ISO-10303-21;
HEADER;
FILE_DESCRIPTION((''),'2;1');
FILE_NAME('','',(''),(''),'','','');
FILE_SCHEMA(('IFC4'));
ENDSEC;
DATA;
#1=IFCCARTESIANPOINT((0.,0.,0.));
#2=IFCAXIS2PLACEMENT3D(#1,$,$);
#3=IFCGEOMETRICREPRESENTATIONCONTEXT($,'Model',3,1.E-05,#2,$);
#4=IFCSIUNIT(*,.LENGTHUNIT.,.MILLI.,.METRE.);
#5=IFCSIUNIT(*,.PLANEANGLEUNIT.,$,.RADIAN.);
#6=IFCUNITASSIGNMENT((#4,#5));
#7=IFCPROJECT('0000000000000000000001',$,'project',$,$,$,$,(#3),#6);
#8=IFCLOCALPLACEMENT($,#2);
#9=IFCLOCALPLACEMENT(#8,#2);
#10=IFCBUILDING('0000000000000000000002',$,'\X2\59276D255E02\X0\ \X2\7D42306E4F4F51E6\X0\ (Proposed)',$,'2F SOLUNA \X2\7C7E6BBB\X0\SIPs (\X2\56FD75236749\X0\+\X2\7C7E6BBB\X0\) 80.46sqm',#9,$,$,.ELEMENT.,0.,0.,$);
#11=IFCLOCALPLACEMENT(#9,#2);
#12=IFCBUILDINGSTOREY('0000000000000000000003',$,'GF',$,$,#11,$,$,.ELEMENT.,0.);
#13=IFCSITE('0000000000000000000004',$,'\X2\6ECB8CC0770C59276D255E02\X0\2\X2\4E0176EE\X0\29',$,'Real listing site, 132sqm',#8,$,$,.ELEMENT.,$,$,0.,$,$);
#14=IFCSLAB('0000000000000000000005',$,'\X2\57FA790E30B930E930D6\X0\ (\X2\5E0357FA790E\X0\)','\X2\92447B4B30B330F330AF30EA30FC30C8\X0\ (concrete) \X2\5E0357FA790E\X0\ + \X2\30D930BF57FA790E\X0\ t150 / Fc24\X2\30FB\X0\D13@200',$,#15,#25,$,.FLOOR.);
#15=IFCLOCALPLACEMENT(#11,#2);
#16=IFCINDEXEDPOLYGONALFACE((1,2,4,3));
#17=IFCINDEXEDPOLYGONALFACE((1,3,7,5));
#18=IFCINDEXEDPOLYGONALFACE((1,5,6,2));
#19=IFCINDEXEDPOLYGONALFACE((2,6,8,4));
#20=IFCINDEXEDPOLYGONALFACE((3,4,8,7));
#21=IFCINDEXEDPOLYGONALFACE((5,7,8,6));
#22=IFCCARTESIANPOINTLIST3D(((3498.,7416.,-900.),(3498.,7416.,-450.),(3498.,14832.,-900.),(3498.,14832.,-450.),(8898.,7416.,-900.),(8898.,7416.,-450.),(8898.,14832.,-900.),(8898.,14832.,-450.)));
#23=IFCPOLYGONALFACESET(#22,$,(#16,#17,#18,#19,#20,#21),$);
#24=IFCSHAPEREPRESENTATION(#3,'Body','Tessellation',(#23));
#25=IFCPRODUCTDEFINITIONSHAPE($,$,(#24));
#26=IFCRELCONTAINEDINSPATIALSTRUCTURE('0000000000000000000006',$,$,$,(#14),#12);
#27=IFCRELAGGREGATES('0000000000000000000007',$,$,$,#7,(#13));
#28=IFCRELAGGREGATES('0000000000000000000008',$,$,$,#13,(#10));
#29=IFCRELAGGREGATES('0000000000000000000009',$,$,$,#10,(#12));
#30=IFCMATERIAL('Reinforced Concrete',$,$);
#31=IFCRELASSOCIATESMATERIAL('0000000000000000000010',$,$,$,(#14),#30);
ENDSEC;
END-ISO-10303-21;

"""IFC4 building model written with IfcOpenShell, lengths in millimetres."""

from ifc_helpers import new_model, si_unit, frame, frame_2d, origin, place, context, project, spatial, rectangle, extrude, material, element, save


model = new_model("IFC4")

# Units and contexts
model_context = context("Model", 3, precision=1e-05, world=origin())
ifc_project = project(units=[si_unit("LENGTHUNIT", "METRE", prefix="MILLI"), si_unit("PLANEANGLEUNIT", "RADIAN")], contexts=[model_context])

# Site, building, storey
site_placement = place(None, origin())
site = spatial("IfcSite", under=ifc_project, at=site_placement, Name="滋賀県大津市2丁目29", ObjectType="Real listing site, 132sqm", CompositionType="ELEMENT", RefElevation=0.0)
building_placement = place(site_placement, origin())
building = spatial("IfcBuilding", under=site, at=building_placement, Name="大津市 終の住処 (Proposed)", ObjectType="2F SOLUNA 籾殻SIPs (国産杉+籾殻) 80.46sqm", CompositionType="ELEMENT", ElevationOfRefHeight=0.0, ElevationOfTerrain=0.0)
storey_placement = place(building_placement, origin())
storey = spatial("IfcBuildingStorey", under=building, at=storey_placement, Name="GF", CompositionType="ELEMENT", Elevation=0.0)

# Slab
ifc_material_1 = material(Name="Reinforced Concrete")
slab_1_placement = place(storey_placement, frame((1749.0, 3708.0, -450.0)))
element("IfcSlab", 1, at=slab_1_placement, inside=storey, material=ifc_material_1, Name="基礎スラブ (布基礎)", Description="鉄筋コンクリート (concrete) 布基礎 + ベタ基礎 t150 / Fc24・D13@200", PredefinedType="FLOOR", context=model_context, shape_type="SweptSolid", body=[
    extrude(rectangle(XDim=5400.0, YDim=7416.0, at=frame_2d((2700.0, 3708.0))), frame((1749.0, 3708.0, -450.0)), (0.0, 0.0, 1.0), 450.0),
])

save(model, "model.ifc")
